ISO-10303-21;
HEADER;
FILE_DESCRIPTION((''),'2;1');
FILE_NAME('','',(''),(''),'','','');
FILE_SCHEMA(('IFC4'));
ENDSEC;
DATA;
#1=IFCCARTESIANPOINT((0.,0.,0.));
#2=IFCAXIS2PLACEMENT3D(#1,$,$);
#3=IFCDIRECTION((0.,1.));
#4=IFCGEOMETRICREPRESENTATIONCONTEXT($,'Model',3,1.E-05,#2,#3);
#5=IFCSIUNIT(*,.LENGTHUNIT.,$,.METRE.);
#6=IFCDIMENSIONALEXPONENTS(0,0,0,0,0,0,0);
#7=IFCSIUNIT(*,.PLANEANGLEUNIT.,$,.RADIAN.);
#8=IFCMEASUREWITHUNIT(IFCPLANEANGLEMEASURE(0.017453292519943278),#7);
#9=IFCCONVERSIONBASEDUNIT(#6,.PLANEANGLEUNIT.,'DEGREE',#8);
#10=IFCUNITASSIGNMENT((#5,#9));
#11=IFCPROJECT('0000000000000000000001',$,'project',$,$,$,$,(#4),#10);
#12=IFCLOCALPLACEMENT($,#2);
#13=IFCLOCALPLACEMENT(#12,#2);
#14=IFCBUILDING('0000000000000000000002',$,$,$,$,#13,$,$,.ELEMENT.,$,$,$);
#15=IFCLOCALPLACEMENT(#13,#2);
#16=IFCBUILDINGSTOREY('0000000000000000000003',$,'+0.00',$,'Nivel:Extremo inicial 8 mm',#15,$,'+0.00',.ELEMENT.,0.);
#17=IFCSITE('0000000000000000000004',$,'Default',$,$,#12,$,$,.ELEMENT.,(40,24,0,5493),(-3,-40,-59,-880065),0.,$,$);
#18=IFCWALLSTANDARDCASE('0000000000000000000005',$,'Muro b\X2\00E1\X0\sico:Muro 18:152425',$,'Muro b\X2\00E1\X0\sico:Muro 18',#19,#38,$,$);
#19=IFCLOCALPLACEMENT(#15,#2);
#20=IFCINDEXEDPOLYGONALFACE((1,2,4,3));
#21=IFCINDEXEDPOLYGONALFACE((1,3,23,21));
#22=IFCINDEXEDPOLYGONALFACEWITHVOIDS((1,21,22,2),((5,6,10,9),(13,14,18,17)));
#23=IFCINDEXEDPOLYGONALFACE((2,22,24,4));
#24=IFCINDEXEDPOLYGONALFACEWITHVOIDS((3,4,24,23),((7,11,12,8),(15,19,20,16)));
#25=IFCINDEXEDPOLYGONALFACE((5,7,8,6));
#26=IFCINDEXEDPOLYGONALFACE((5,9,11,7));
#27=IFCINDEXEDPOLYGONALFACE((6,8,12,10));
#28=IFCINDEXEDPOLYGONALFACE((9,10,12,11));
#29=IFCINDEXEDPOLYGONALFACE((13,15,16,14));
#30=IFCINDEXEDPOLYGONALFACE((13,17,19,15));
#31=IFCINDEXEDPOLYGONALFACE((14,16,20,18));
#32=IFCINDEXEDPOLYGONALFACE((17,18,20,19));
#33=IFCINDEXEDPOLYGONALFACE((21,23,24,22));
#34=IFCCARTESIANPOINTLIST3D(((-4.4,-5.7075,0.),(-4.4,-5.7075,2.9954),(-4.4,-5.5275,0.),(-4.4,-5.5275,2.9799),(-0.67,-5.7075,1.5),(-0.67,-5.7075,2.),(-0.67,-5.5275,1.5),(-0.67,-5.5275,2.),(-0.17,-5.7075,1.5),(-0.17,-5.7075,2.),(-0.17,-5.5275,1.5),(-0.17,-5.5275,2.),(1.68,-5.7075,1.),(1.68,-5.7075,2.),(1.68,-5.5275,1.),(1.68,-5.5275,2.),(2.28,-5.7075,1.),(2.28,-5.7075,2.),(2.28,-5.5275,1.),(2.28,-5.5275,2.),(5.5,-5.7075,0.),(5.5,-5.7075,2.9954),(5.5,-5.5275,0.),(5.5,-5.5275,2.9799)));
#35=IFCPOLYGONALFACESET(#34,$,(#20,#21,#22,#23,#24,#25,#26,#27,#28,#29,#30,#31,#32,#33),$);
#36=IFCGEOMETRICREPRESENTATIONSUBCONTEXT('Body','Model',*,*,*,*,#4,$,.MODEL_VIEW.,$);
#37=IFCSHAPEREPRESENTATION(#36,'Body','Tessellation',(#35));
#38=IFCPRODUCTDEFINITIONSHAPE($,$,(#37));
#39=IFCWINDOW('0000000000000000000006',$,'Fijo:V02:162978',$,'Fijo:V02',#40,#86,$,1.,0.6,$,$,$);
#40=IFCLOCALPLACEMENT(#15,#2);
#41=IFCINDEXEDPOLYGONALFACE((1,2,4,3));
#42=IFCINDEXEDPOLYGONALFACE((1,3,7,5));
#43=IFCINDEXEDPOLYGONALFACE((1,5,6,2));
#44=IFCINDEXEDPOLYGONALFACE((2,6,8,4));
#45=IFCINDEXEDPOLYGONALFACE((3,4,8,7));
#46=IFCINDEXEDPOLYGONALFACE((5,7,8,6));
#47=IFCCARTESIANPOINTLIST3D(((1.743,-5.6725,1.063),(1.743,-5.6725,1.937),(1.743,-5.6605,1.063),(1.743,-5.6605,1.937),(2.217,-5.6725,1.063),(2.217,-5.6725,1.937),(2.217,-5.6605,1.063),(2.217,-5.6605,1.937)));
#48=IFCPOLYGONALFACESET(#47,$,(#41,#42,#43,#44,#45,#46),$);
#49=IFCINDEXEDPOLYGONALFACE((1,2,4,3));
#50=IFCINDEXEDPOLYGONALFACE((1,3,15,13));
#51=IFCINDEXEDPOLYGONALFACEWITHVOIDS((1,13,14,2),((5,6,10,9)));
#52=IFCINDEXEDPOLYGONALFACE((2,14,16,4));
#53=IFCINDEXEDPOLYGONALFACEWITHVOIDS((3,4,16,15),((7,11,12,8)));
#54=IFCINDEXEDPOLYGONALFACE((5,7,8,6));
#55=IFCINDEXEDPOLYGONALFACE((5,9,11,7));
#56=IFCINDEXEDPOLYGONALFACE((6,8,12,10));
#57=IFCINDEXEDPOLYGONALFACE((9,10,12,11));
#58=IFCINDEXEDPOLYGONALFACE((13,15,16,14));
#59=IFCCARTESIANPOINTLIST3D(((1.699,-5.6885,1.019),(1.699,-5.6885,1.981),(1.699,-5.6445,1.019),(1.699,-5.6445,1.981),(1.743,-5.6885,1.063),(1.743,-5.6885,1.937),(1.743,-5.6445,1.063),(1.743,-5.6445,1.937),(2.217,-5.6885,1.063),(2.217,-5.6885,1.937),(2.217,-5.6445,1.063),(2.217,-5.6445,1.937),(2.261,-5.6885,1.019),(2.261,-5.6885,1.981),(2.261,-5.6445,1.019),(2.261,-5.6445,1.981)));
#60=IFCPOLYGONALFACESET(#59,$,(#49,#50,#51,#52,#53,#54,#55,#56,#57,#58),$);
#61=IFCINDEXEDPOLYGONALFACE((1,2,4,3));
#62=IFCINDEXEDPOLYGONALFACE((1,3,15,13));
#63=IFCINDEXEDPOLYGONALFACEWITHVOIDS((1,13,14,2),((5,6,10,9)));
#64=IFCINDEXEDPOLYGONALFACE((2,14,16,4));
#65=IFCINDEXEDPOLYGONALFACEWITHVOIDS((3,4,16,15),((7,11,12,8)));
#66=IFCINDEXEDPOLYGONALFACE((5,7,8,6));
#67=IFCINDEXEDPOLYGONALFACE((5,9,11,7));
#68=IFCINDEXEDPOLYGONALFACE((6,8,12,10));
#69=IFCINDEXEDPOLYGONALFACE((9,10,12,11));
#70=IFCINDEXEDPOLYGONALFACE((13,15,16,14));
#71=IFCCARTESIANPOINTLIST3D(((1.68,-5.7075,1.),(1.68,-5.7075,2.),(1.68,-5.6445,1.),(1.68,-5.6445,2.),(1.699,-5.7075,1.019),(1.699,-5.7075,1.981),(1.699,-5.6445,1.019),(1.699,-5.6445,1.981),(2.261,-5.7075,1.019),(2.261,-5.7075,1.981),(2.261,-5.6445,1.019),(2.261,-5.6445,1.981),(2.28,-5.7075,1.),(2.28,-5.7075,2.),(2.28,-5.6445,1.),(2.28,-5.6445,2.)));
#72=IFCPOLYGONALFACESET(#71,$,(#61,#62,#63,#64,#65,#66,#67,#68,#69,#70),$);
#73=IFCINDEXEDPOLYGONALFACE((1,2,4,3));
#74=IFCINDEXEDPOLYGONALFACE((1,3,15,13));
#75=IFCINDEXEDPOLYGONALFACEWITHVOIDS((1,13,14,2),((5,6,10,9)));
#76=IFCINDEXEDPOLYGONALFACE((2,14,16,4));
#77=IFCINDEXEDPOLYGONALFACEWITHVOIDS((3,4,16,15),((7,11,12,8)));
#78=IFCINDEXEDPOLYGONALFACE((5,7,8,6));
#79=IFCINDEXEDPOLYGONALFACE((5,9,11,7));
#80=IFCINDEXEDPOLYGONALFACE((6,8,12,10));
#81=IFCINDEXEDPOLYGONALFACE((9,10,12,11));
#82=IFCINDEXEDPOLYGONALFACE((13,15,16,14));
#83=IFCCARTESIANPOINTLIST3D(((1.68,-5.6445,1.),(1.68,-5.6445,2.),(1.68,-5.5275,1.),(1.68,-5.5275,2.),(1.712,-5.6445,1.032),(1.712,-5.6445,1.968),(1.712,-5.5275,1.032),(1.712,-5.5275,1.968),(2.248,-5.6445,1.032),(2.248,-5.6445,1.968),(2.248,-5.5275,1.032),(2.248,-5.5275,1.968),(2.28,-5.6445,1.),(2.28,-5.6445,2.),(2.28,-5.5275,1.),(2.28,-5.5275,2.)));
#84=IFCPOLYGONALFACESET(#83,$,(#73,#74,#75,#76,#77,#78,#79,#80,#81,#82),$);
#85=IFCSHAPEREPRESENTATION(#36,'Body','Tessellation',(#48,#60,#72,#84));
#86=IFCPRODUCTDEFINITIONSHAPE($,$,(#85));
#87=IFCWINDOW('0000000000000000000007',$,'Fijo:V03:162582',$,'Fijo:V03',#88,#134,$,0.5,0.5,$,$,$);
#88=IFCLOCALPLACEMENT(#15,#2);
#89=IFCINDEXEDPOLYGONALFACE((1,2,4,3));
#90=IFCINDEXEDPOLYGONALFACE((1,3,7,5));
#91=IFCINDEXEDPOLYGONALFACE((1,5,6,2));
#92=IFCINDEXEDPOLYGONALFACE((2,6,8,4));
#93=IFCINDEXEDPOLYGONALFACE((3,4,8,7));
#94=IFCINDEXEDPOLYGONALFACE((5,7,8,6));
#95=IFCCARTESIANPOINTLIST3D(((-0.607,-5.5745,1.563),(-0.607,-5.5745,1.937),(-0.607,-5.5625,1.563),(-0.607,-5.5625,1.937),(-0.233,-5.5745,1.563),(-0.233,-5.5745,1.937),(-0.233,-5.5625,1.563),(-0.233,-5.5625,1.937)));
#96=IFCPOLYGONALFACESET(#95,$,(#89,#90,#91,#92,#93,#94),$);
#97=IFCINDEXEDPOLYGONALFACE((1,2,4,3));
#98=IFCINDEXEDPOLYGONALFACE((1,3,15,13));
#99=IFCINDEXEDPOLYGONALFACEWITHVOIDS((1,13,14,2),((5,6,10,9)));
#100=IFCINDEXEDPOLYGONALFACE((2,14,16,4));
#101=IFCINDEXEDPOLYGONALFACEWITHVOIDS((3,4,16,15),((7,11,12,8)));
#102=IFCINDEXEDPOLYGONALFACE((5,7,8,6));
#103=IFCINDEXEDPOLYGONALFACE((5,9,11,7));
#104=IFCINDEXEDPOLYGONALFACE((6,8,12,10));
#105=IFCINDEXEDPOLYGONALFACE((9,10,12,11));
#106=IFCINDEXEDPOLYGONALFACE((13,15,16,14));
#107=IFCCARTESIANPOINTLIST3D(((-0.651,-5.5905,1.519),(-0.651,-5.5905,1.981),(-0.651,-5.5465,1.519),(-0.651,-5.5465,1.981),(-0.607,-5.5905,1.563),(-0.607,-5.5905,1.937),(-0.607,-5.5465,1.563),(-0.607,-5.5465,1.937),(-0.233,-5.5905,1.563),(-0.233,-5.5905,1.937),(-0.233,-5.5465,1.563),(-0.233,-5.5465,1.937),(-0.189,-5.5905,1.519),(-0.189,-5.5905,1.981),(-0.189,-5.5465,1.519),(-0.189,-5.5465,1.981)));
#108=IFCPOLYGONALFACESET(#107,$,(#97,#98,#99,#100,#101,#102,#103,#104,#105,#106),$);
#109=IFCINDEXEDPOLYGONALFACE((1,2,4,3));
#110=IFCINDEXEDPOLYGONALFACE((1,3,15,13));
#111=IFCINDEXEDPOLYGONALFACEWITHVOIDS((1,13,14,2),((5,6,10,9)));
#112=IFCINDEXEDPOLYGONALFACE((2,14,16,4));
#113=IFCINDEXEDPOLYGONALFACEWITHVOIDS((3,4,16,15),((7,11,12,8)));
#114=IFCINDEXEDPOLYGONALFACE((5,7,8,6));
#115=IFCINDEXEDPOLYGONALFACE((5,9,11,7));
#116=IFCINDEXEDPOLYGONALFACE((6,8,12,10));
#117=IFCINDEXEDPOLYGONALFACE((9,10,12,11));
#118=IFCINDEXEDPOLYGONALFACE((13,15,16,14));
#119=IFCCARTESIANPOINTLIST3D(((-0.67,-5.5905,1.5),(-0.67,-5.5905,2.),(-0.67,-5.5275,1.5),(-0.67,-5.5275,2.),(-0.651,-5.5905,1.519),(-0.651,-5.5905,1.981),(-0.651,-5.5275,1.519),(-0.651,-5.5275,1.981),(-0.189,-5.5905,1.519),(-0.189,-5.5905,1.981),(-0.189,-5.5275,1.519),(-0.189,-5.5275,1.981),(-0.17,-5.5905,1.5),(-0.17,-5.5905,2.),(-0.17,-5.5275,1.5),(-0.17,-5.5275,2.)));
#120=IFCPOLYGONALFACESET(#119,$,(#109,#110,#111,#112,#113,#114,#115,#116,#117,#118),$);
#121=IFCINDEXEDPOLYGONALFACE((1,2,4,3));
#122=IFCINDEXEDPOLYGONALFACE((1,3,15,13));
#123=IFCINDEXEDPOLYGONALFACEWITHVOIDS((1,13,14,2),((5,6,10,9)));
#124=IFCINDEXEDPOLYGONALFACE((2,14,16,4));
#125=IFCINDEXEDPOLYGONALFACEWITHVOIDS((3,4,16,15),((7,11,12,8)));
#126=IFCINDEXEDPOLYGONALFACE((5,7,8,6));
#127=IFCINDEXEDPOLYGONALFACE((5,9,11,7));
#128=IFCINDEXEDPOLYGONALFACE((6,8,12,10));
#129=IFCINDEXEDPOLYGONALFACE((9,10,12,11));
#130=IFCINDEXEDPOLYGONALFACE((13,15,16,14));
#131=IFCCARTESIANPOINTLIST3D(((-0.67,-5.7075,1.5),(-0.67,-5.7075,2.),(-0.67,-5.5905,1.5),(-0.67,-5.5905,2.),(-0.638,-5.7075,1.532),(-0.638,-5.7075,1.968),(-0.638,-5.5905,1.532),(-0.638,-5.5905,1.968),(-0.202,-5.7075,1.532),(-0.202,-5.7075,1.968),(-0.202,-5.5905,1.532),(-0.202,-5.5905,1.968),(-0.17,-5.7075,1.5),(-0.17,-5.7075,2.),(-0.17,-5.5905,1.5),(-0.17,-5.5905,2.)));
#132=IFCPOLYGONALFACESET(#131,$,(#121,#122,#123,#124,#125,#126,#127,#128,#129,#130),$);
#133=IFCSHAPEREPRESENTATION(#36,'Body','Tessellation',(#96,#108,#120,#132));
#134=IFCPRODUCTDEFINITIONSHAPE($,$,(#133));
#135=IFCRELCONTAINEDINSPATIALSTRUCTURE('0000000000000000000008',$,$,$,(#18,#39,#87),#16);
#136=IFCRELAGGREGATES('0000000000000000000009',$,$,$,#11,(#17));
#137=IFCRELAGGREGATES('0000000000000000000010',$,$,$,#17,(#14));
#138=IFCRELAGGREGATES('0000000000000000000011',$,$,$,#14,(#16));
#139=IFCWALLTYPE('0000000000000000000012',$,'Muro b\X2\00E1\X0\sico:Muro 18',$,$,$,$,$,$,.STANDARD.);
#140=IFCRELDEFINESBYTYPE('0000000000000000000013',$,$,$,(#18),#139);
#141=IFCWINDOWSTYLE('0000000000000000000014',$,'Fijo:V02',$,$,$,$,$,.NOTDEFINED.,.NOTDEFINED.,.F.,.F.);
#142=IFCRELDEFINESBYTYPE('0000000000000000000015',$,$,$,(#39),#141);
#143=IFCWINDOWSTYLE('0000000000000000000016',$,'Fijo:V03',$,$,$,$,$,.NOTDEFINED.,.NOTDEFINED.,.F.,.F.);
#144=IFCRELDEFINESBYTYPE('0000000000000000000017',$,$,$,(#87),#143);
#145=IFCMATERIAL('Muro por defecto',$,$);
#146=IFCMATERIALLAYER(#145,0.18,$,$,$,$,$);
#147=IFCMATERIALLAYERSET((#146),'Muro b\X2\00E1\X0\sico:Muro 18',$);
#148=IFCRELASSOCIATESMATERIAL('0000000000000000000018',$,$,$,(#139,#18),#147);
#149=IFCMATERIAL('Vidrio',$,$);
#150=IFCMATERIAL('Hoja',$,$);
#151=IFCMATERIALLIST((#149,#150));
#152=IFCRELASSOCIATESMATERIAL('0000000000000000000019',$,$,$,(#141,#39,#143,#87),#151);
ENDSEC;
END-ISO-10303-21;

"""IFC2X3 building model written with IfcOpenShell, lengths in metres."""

from ifc_helpers import new_model, entity, si_unit, converted_unit, direction, frame, frame_2d, origin, place, context, subcontext, project, spatial, polyline, rectangle, outline, extrude, clip, bounded_halfspace, source, transform, mapped, material, material_list, layer, layer_set, layer_usage, type_object, type_shapes, element, fill, save


model = new_model("IFC2X3")

# Units and contexts
model_context = context("Model", 3, precision=1e-05, world=origin(), true_north=direction((0.0, 1.0)))
body_context = subcontext(model_context, "Body", "Model", "MODEL_VIEW")
ifc_project = project(units=[si_unit("LENGTHUNIT", "METRE"), converted_unit("PLANEANGLEUNIT", "DEGREE", entity("IfcPlaneAngleMeasure", 0.017453292519943278), si_unit("PLANEANGLEUNIT", "RADIAN"), dimensions=[0, 0, 0, 0, 0, 0, 0])], contexts=[model_context])

# Site, building, storey
site_placement = place(None, origin())
site = spatial("IfcSite", under=ifc_project, at=site_placement, Name="Default", CompositionType="ELEMENT", RefLatitude=(40, 24, 0, 5493), RefLongitude=(-3, -40, -59, -880065), RefElevation=0.0)
building_placement = place(site_placement, origin())
building = spatial("IfcBuilding", under=site, at=building_placement, CompositionType="ELEMENT")
storey_placement = place(building_placement, origin())
storey = spatial("IfcBuildingStorey", under=building, at=storey_placement, Name="+0.00", ObjectType="Nivel:Extremo inicial 8 mm", LongName="+0.00", CompositionType="ELEMENT", Elevation=0.0)

# Wall, openings, windows
ifc_material_1 = material(Name="Muro por defecto")
ifc_layer = layer(ifc_material_1, 0.18)
ifc_layer_set = layer_set([ifc_layer], Name="Muro básico:Muro 18")
wall_type = type_object("IfcWallType", Name="Muro básico:Muro 18", PredefinedType="STANDARD", material=ifc_layer_set)
ifc_material_2 = material(Name="Vidrio")
ifc_material_3 = material(Name="Hoja")
ifc_material_list_1 = material_list([ifc_material_2, ifc_material_3])
ifc_layer_usage_1 = layer_usage(ifc_layer_set, "AXIS2", "POSITIVE", -0.09)
wall_1_placement = place(storey_placement, frame((-4.4, -5.6175, 0.0)))
wall_1 = element("IfcWallStandardCase", 1, at=wall_1_placement, inside=storey, type_object=wall_type, material=ifc_layer_usage_1, Name="Muro básico:Muro 18:152425", ObjectType="Muro básico:Muro 18", context=body_context, shape_type="Clipping", body=[
    clip(extrude(rectangle(XDim=9.9, YDim=0.18, at=frame_2d((4.95, 0.0), x_axis=(-1.0, 0.0))), origin(), (0.0, 0.0, 1.0), 2.9954), bounded_halfspace(frame((0.0, -0.09, 2.9954), z_axis=(0.0, 0.085882, 0.996305), x_axis=(-1.0, 0.0, 0.0)), False, frame((0.0, -0.09, 2.9954)), polyline([(0.0, 0.0), (9.9, 0.0), (9.9, 0.18), (5.19, 0.18), (5.01, 0.18), (3.54, 0.18), (3.36, 0.18), (0.0, 0.18), (0.0, 0.0)]))),
])
opening_1_placement = place(wall_1_placement, frame((3.73, -0.09, 1.5)))
opening_1 = element("IfcOpeningElement", 2, at=opening_1_placement, cuts=wall_1, ObjectType="Opening", context=body_context, shape_type="SweptSolid", body=[
    extrude(rectangle(XDim=0.5, YDim=0.5, at=frame_2d((0.25, 0.25), x_axis=(1.0, 0.0))), frame((0.0, 0.0, 0.0), z_axis=(0.0, 1.0, 0.0), x_axis=(0.0, 0.0, 1.0)), (0.0, 0.0, 1.0), 0.18),
])
opening_2_placement = place(wall_1_placement, frame((6.68, 0.09, 1.0)))
opening_2 = element("IfcOpeningElement", 3, at=opening_2_placement, cuts=wall_1, ObjectType="Opening", context=body_context, shape_type="SweptSolid", body=[
    extrude(rectangle(XDim=1.0, YDim=0.6, at=frame_2d((0.5, 0.3), x_axis=(1.0, 0.0))), frame((0.0, 0.0, 0.0), z_axis=(0.0, -1.0, 0.0), x_axis=(0.0, 0.0, 1.0)), (0.0, 0.0, 1.0), 0.18),
])
window_style_1 = type_object("IfcWindowStyle", Name="Fijo:V02", ConstructionType="NOTDEFINED", OperationType="NOTDEFINED", ParameterTakesPrecedence=False, Sizeable=False, material=ifc_material_list_1)
shared_shape_1 = source(origin(), body_context, "Body", "SweptSolid", [
    extrude(rectangle(XDim=0.012, YDim=0.474, at=frame_2d((0.0, 0.0), x_axis=(1.0, 0.0))), frame((0.3, 0.139, 0.063), z_axis=(0.0, 0.0, 1.0), x_axis=(0.0, -1.0, 0.0)), (0.0, 0.0, 1.0), 0.874),
    extrude(outline(polyline([(-0.281, -0.481), (0.281, -0.481), (0.281, 0.481), (-0.281, 0.481), (-0.281, -0.481)]), holes=[polyline([(-0.237, -0.437), (-0.237, 0.437), (0.237, 0.437), (0.237, -0.437), (-0.237, -0.437)])]), frame((0.3, 0.117, 0.5), z_axis=(0.0, 1.0, 0.0), x_axis=(1.0, 0.0, 0.0)), (0.0, 0.0, 1.0), 0.044),
    extrude(outline(polyline([(-0.3, -0.5), (0.3, -0.5), (0.3, 0.5), (-0.3, 0.5), (-0.3, -0.5)]), holes=[polyline([(-0.281, -0.481), (-0.281, 0.481), (0.281, 0.481), (0.281, -0.481), (-0.281, -0.481)])]), frame((0.3, 0.117, 0.5), z_axis=(0.0, 1.0, 0.0), x_axis=(1.0, 0.0, 0.0)), (0.0, 0.0, 1.0), 0.063),
    extrude(outline(polyline([(-0.3, -0.5), (0.3, -0.5), (0.3, 0.5), (-0.3, 0.5), (-0.3, -0.5)]), holes=[polyline([(-0.268, -0.468), (-0.268, 0.468), (0.268, 0.468), (0.268, -0.468), (-0.268, -0.468)])]), frame((0.3, 0.0, 0.5), z_axis=(0.0, 1.0, 0.0), x_axis=(1.0, 0.0, 0.0)), (0.0, 0.0, 1.0), 0.117),
])
type_shapes(window_style_1, [shared_shape_1])
window_1_placement = place(opening_2_placement, frame((0.0, 0.0, 0.0), z_axis=(0.0, 0.0, 1.0), x_axis=(-1.0, 0.0, 0.0)))
window_1 = element("IfcWindow", 4, at=window_1_placement, inside=storey, type_object=window_style_1, material=ifc_material_list_1, Name="Fijo:V02:162978", ObjectType="Fijo:V02", OverallHeight=1.0, OverallWidth=0.6, context=body_context, shape_type="MappedRepresentation", body=[
    mapped(shared_shape_1, transform((0.0, 0.0, 0.0), scale=1.0)),
])
fill(opening_2, window_1)
window_style_2 = type_object("IfcWindowStyle", Name="Fijo:V03", ConstructionType="NOTDEFINED", OperationType="NOTDEFINED", ParameterTakesPrecedence=False, Sizeable=False, material=ifc_material_list_1)
shared_shape_2 = source(origin(), body_context, "Body", "SweptSolid", [
    extrude(rectangle(XDim=0.012, YDim=0.374, at=frame_2d((0.0, 0.0), x_axis=(1.0, 0.0))), frame((0.25, 0.139, 0.063), z_axis=(0.0, 0.0, 1.0), x_axis=(0.0, -1.0, 0.0)), (0.0, 0.0, 1.0), 0.374),
    extrude(outline(polyline([(-0.231, -0.231), (0.231, -0.231), (0.231, 0.231), (-0.231, 0.231), (-0.231, -0.231)]), holes=[polyline([(-0.187, -0.187), (-0.187, 0.187), (0.187, 0.187), (0.187, -0.187), (-0.187, -0.187)])]), frame((0.25, 0.117, 0.25), z_axis=(0.0, 1.0, 0.0), x_axis=(1.0, 0.0, 0.0)), (0.0, 0.0, 1.0), 0.044),
    extrude(outline(polyline([(-0.25, -0.25), (0.25, -0.25), (0.25, 0.25), (-0.25, 0.25), (-0.25, -0.25)]), holes=[polyline([(-0.231, -0.231), (-0.231, 0.231), (0.231, 0.231), (0.231, -0.231), (-0.231, -0.231)])]), frame((0.25, 0.117, 0.25), z_axis=(0.0, 1.0, 0.0), x_axis=(1.0, 0.0, 0.0)), (0.0, 0.0, 1.0), 0.063),
    extrude(outline(polyline([(-0.25, -0.25), (0.25, -0.25), (0.25, 0.25), (-0.25, 0.25), (-0.25, -0.25)]), holes=[polyline([(-0.218, -0.218), (-0.218, 0.218), (0.218, 0.218), (0.218, -0.218), (-0.218, -0.218)])]), frame((0.25, 0.0, 0.25), z_axis=(0.0, 1.0, 0.0), x_axis=(1.0, 0.0, 0.0)), (0.0, 0.0, 1.0), 0.117),
])
type_shapes(window_style_2, [shared_shape_2])
window_2_placement = place(opening_1_placement, origin())
window_2 = element("IfcWindow", 5, at=window_2_placement, inside=storey, type_object=window_style_2, material=ifc_material_list_1, Name="Fijo:V03:162582", ObjectType="Fijo:V03", OverallHeight=0.5, OverallWidth=0.5, context=body_context, shape_type="MappedRepresentation", body=[
    mapped(shared_shape_2, transform((0.0, 0.0, 0.0), scale=1.0)),
])
fill(opening_1, window_2)

save(model, "model.ifc")
